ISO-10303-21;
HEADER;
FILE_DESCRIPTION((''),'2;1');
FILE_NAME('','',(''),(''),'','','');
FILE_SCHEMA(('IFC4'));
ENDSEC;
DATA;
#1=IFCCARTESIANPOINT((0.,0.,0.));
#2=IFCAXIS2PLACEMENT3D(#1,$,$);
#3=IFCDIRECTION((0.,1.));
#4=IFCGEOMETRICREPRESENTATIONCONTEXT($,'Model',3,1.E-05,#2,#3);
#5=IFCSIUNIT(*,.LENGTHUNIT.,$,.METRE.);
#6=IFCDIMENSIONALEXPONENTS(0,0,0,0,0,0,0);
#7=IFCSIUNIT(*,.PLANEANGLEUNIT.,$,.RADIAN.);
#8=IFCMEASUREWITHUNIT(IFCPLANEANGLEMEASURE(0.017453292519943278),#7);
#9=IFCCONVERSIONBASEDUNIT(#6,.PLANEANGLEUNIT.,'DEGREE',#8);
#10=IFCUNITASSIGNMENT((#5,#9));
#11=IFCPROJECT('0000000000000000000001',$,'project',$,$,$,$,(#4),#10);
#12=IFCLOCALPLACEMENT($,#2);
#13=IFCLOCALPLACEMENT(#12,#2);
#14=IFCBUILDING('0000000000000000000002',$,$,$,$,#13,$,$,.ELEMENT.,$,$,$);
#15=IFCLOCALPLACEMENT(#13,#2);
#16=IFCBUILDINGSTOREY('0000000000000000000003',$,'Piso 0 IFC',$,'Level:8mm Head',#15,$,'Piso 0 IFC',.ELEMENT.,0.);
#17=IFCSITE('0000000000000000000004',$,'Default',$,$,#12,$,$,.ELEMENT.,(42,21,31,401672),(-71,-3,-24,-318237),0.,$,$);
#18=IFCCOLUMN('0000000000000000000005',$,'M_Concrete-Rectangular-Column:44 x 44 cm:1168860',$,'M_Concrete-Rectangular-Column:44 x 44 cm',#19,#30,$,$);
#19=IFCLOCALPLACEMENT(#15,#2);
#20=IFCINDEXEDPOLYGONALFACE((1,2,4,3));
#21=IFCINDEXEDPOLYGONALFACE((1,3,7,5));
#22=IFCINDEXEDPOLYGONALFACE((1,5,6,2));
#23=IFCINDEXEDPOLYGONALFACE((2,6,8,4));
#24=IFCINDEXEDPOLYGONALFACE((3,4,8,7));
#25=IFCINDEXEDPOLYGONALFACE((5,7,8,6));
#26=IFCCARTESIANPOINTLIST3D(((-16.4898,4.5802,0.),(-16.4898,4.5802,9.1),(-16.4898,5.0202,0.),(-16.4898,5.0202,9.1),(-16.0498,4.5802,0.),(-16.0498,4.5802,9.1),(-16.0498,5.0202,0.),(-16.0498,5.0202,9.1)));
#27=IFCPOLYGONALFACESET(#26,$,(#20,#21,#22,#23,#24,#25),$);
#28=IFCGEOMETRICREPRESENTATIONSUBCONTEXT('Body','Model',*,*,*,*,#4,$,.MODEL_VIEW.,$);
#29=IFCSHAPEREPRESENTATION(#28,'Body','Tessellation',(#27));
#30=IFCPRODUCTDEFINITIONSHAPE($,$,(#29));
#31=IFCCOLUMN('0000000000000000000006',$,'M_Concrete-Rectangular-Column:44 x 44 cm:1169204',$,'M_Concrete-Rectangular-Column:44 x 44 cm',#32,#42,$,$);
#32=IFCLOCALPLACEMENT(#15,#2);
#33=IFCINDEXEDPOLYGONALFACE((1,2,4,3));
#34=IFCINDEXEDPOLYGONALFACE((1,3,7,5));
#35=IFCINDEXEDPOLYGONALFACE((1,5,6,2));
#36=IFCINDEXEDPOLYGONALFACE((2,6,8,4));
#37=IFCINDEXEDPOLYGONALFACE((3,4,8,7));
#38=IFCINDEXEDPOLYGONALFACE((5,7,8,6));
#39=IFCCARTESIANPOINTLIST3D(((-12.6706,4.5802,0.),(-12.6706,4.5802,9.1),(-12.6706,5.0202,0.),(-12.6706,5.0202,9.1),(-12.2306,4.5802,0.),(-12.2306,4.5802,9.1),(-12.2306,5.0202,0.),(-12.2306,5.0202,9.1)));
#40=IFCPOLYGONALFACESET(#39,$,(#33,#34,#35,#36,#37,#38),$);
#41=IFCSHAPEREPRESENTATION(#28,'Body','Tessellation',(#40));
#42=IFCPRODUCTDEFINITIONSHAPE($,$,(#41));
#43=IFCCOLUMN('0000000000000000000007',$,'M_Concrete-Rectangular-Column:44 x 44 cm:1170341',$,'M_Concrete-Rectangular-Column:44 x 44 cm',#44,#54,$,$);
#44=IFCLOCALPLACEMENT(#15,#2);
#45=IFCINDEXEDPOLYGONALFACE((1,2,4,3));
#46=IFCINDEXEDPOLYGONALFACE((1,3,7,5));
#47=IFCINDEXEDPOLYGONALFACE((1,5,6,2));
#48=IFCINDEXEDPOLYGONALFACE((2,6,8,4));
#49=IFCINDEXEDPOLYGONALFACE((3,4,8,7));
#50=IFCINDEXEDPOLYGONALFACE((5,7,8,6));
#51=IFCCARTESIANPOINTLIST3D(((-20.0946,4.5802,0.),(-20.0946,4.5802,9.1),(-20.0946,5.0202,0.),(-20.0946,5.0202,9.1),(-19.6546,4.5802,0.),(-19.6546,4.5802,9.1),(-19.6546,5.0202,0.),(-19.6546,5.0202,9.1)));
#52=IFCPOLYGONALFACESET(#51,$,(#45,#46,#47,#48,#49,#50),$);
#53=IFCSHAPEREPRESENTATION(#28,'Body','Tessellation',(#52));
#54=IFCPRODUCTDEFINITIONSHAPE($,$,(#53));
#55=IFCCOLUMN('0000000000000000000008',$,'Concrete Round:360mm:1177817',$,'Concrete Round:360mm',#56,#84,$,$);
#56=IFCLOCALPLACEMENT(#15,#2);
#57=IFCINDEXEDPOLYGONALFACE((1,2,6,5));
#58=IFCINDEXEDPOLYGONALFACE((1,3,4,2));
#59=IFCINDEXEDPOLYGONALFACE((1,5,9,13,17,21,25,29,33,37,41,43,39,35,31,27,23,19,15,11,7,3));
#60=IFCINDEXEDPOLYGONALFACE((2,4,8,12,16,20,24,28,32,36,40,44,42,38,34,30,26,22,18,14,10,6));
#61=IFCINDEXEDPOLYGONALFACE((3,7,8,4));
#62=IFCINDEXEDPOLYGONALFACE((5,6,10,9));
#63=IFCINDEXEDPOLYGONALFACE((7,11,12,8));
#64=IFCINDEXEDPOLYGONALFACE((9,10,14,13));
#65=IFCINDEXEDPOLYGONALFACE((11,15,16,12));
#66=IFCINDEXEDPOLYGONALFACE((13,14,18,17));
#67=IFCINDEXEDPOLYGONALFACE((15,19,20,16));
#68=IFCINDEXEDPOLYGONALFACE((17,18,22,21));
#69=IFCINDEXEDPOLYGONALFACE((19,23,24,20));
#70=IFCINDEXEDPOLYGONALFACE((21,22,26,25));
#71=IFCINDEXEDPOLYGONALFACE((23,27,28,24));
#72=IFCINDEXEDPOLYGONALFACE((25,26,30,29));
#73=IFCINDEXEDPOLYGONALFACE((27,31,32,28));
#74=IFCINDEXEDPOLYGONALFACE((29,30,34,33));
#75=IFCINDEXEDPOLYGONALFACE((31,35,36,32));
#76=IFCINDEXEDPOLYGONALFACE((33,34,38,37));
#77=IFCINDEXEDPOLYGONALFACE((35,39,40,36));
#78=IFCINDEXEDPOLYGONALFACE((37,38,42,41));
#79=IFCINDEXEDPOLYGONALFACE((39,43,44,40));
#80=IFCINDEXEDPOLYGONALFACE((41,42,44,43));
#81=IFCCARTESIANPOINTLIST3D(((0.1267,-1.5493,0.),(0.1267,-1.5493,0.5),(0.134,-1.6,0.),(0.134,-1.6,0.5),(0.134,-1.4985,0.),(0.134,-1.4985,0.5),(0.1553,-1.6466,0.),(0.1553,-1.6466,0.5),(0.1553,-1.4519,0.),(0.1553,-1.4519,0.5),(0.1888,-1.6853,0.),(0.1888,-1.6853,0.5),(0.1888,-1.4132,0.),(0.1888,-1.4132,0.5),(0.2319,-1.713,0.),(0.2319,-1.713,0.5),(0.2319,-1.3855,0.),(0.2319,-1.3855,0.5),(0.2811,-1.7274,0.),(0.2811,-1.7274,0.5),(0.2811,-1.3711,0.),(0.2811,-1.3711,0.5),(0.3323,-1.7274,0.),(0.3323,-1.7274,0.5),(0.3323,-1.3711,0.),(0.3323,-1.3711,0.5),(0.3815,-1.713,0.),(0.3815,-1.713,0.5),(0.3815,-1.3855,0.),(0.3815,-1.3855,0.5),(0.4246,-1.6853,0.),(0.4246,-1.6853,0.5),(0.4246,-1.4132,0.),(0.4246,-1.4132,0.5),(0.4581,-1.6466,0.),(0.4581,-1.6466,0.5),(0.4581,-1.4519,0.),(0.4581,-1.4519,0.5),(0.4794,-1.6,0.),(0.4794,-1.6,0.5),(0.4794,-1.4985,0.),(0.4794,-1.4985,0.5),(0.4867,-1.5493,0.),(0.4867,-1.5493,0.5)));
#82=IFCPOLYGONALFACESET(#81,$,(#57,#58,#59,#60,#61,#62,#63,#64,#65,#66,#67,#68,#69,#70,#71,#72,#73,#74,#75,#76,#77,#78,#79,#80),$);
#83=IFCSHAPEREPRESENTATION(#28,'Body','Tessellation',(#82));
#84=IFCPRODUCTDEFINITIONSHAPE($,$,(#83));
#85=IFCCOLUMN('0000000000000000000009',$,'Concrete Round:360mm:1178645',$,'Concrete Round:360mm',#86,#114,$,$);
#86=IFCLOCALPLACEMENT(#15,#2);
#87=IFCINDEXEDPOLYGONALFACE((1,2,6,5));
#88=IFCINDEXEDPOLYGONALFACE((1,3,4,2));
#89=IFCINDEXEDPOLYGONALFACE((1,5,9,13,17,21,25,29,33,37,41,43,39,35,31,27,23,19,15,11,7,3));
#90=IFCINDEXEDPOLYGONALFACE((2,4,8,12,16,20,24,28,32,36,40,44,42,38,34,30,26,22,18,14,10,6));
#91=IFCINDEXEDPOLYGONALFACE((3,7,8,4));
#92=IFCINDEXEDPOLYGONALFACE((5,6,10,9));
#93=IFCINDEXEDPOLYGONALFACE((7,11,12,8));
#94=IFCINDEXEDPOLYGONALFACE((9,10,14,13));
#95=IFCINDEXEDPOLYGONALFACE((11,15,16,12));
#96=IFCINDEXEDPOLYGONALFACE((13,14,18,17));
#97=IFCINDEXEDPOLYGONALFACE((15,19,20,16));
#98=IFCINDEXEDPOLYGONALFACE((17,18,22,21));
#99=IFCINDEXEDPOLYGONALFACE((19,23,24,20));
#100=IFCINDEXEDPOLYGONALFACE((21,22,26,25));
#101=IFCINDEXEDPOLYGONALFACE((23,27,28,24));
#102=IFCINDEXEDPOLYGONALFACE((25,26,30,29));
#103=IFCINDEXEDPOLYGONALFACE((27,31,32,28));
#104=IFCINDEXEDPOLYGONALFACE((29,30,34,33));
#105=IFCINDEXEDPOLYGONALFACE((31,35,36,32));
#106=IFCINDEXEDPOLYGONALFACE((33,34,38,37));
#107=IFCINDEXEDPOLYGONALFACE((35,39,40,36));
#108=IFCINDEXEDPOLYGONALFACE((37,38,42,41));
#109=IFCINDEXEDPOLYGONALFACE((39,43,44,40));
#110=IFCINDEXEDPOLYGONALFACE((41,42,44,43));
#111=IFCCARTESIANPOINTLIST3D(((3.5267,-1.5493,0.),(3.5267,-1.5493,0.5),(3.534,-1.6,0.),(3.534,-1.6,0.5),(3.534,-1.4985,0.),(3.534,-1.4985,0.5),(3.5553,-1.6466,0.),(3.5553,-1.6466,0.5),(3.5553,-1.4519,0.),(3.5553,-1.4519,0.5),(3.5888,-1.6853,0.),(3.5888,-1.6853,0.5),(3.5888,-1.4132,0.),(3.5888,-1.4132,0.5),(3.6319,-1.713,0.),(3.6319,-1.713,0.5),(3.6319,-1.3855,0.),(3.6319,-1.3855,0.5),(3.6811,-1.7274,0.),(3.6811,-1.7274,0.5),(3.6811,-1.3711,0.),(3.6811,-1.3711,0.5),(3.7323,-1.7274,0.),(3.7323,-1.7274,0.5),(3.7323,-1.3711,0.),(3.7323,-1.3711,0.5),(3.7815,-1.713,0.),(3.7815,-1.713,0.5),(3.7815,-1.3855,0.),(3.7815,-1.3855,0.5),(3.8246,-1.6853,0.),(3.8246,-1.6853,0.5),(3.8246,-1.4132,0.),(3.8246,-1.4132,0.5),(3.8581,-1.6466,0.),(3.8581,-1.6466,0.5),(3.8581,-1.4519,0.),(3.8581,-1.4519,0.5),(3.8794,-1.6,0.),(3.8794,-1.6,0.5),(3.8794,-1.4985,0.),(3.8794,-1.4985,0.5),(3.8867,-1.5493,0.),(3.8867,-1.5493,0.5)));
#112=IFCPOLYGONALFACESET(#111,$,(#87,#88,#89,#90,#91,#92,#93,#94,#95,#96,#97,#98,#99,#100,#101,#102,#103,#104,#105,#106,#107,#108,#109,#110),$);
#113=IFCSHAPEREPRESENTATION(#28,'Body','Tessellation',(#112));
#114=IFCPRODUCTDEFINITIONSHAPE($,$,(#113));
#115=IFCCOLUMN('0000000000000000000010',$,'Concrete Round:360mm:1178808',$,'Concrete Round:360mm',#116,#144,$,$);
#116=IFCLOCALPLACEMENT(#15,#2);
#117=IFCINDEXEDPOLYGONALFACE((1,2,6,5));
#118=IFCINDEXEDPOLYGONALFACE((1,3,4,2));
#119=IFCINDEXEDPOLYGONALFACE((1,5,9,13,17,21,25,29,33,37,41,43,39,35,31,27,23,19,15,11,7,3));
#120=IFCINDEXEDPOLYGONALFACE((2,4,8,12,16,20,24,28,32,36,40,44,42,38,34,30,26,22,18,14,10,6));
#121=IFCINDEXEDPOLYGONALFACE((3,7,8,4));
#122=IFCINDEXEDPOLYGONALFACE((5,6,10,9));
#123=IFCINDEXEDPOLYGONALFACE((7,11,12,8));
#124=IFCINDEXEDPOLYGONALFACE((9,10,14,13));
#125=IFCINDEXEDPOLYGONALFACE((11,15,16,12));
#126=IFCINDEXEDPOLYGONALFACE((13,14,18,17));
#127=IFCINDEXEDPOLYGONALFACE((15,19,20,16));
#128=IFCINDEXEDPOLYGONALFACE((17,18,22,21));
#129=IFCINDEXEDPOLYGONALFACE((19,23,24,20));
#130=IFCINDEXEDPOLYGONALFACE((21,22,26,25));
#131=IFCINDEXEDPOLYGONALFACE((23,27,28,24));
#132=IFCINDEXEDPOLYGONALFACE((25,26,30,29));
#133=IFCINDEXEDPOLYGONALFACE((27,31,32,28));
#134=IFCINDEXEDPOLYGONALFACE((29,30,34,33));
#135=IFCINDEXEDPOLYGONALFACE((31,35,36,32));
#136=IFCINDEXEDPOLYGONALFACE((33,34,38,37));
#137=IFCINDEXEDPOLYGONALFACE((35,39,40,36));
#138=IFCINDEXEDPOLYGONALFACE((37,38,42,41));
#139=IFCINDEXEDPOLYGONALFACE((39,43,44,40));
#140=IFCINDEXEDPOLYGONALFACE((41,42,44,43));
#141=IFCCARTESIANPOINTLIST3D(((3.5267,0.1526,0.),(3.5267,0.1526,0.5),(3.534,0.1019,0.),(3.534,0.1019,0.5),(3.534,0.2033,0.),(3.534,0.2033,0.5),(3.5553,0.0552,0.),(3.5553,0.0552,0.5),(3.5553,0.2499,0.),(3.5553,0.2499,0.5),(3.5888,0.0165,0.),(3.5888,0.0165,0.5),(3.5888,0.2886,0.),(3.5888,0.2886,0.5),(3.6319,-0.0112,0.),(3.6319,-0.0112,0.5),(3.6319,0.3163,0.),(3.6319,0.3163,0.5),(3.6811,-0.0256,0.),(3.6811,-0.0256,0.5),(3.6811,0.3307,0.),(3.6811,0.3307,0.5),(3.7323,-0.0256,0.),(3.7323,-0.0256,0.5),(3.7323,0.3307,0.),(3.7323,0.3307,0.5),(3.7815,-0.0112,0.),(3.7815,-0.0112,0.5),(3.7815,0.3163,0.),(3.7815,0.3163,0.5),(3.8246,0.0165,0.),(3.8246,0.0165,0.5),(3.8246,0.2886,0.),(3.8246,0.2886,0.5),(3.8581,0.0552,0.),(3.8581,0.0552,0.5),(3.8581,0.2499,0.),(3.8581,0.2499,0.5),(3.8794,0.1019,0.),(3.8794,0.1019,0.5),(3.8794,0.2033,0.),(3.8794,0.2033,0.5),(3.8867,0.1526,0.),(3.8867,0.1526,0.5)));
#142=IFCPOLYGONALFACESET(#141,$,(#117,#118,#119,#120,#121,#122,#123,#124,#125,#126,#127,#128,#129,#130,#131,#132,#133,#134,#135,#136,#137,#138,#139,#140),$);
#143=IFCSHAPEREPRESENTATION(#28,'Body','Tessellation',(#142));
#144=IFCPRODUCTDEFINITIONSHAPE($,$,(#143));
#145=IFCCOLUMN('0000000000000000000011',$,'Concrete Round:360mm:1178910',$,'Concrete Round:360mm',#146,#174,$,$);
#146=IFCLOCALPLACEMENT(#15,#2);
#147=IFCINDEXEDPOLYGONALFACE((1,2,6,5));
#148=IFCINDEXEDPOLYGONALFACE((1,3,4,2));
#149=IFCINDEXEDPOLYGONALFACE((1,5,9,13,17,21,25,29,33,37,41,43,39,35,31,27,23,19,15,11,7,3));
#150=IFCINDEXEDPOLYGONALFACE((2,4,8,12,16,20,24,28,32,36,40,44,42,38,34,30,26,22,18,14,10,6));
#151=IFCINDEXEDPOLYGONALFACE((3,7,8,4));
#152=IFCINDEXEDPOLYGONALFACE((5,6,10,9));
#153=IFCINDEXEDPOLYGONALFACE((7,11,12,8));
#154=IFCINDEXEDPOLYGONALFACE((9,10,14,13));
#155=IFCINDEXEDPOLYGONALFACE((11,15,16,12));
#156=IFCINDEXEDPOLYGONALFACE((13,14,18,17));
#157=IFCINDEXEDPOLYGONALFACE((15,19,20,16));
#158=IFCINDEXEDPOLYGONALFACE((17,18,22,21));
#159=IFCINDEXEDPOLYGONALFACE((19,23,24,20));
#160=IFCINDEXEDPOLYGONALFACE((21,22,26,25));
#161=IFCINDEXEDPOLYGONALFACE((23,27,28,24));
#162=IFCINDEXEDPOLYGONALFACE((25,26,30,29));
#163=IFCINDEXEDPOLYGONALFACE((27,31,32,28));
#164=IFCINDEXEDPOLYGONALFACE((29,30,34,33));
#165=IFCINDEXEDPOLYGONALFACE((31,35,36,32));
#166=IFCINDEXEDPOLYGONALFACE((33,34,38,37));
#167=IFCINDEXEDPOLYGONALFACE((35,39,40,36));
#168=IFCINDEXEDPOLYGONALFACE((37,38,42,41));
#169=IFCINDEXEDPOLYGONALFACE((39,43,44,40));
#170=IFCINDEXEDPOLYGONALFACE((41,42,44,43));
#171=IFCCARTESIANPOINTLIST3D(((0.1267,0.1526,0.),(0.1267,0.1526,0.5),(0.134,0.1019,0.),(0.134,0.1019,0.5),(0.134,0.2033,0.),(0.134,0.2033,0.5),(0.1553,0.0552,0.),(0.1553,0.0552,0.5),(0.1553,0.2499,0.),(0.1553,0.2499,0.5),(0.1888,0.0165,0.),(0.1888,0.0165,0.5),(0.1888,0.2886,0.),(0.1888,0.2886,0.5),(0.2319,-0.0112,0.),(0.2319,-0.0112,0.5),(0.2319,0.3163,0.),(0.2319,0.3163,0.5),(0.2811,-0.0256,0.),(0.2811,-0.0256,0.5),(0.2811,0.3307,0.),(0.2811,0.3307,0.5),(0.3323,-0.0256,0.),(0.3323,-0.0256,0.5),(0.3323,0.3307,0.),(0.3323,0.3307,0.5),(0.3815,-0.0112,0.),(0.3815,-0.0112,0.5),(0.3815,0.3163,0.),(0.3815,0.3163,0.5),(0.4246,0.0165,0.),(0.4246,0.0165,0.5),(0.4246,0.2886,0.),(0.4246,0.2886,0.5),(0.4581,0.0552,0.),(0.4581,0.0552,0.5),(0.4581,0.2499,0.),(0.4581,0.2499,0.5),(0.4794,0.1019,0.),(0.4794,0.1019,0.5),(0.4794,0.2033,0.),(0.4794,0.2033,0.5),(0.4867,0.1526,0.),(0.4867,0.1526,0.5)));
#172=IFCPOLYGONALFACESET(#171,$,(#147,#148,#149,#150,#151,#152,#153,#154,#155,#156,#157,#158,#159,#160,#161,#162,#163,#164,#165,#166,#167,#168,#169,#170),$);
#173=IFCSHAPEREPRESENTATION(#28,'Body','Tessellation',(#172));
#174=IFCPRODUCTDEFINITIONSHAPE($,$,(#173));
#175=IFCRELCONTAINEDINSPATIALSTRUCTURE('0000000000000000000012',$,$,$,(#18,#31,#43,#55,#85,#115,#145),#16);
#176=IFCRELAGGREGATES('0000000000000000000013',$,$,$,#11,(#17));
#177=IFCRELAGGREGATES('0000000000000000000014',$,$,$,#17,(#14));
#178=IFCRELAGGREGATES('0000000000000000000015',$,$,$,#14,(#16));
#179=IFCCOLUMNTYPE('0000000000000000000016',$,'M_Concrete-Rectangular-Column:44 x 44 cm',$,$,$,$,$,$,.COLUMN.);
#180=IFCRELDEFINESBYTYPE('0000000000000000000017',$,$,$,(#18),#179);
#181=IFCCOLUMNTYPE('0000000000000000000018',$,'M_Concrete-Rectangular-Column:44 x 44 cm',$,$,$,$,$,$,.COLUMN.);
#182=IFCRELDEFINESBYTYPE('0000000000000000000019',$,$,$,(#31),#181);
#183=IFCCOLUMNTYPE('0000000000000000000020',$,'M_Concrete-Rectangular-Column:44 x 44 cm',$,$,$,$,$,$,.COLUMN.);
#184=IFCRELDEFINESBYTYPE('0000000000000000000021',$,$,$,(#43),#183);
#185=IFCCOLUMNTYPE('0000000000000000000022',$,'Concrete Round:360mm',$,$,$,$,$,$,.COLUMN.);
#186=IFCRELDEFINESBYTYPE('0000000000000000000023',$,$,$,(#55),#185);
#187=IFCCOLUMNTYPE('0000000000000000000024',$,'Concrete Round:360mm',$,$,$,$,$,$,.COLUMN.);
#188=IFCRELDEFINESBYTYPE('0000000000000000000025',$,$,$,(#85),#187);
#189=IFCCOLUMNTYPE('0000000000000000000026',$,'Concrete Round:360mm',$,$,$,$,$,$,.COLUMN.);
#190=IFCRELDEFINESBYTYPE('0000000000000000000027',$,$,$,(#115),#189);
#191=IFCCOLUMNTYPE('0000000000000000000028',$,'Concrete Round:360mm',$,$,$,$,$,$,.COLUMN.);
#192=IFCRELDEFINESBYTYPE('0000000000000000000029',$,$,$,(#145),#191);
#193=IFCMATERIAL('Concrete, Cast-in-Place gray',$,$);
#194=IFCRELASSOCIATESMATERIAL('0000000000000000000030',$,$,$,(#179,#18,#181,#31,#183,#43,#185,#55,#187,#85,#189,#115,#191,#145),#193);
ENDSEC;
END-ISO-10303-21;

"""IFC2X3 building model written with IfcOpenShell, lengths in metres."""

from ifc_helpers import new_model, entity, si_unit, converted_unit, direction, frame, frame_2d, origin, place, context, subcontext, project, spatial, rectangle, circle, extrude, source, transform, mapped, material, type_object, type_shapes, element, save


model = new_model("IFC2X3")

# Units and contexts
model_context = context("Model", 3, precision=1e-05, world=origin(), true_north=direction((0.0, 1.0)))
body_context = subcontext(model_context, "Body", "Model", "MODEL_VIEW")
ifc_project = project(units=[si_unit("LENGTHUNIT", "METRE"), converted_unit("PLANEANGLEUNIT", "DEGREE", entity("IfcPlaneAngleMeasure", 0.017453292519943278), si_unit("PLANEANGLEUNIT", "RADIAN"), dimensions=[0, 0, 0, 0, 0, 0, 0])], contexts=[model_context])

# Site, building, storey
site_placement = place(None, origin())
site = spatial("IfcSite", under=ifc_project, at=site_placement, Name="Default", CompositionType="ELEMENT", RefLatitude=(42, 21, 31, 401672), RefLongitude=(-71, -3, -24, -318237), RefElevation=0.0)
building_placement = place(site_placement, origin())
building = spatial("IfcBuilding", under=site, at=building_placement, CompositionType="ELEMENT")
storey_placement = place(building_placement, origin())
storey = spatial("IfcBuildingStorey", under=building, at=storey_placement, Name="Piso 0 IFC", ObjectType="Level:8mm Head", LongName="Piso 0 IFC", CompositionType="ELEMENT", Elevation=0.0)

# Columns
ifc_material_1 = material(Name="Concrete, Cast-in-Place gray")
column_type_1 = type_object("IfcColumnType", Name="M_Concrete-Rectangular-Column:44 x 44 cm", PredefinedType="COLUMN", material=ifc_material_1)
shared_shape_1 = source(origin(), body_context, "Body", "SweptSolid", [
    extrude(rectangle(XDim=0.44, YDim=0.44, at=frame_2d((0.0, 0.0), x_axis=(1.0, 0.0))), frame((-16.2698, 4.8002, 0.0), z_axis=(0.0, 0.0, 1.0), x_axis=(-1.0, 0.0, 0.0)), (0.0, 0.0, 1.0), 9.1),
])
type_shapes(column_type_1, [shared_shape_1])
column_1_placement = place(storey_placement, origin())
element("IfcColumn", 1, at=column_1_placement, inside=storey, type_object=column_type_1, material=ifc_material_1, Name="M_Concrete-Rectangular-Column:44 x 44 cm:1168860", ObjectType="M_Concrete-Rectangular-Column:44 x 44 cm", context=body_context, shape_type="MappedRepresentation", body=[
    mapped(shared_shape_1, transform((0.0, 0.0, 0.0), scale=1.0)),
])
column_type_2 = type_object("IfcColumnType", Name="M_Concrete-Rectangular-Column:44 x 44 cm", PredefinedType="COLUMN", material=ifc_material_1)
shared_shape_2 = source(origin(), body_context, "Body", "SweptSolid", [
    extrude(rectangle(XDim=0.44, YDim=0.44, at=frame_2d((0.0, 0.0), x_axis=(1.0, 0.0))), frame((-12.4506, 4.8002, 0.0), z_axis=(0.0, 0.0, 1.0), x_axis=(-1.0, 0.0, 0.0)), (0.0, 0.0, 1.0), 9.1),
])
type_shapes(column_type_2, [shared_shape_2])
column_2_placement = place(storey_placement, origin())
element("IfcColumn", 2, at=column_2_placement, inside=storey, type_object=column_type_2, material=ifc_material_1, Name="M_Concrete-Rectangular-Column:44 x 44 cm:1169204", ObjectType="M_Concrete-Rectangular-Column:44 x 44 cm", context=body_context, shape_type="MappedRepresentation", body=[
    mapped(shared_shape_2, transform((0.0, 0.0, 0.0), scale=1.0)),
])
column_type_3 = type_object("IfcColumnType", Name="M_Concrete-Rectangular-Column:44 x 44 cm", PredefinedType="COLUMN", material=ifc_material_1)
shared_shape_3 = source(origin(), body_context, "Body", "SweptSolid", [
    extrude(rectangle(XDim=0.44, YDim=0.44, at=frame_2d((0.0, 0.0), x_axis=(1.0, 0.0))), frame((-19.8746, 4.8002, 0.0), z_axis=(0.0, 0.0, 1.0), x_axis=(-1.0, 0.0, 0.0)), (0.0, 0.0, 1.0), 9.1),
])
type_shapes(column_type_3, [shared_shape_3])
column_3_placement = place(storey_placement, origin())
element("IfcColumn", 3, at=column_3_placement, inside=storey, type_object=column_type_3, material=ifc_material_1, Name="M_Concrete-Rectangular-Column:44 x 44 cm:1170341", ObjectType="M_Concrete-Rectangular-Column:44 x 44 cm", context=body_context, shape_type="MappedRepresentation", body=[
    mapped(shared_shape_3, transform((0.0, 0.0, 0.0), scale=1.0)),
])
column_type_4 = type_object("IfcColumnType", Name="Concrete Round:360mm", PredefinedType="COLUMN", material=ifc_material_1)
shared_shape_4 = source(origin(), body_context, "Body", "SweptSolid", [
    extrude(circle(Radius=0.18, at=frame_2d((0.0, 0.0), x_axis=(1.0, 0.0))), frame((0.3067, -1.5493, 0.0)), (0.0, 0.0, 1.0), 0.5),
])
type_shapes(column_type_4, [shared_shape_4])
column_4_placement = place(storey_placement, origin())
element("IfcColumn", 4, at=column_4_placement, inside=storey, type_object=column_type_4, material=ifc_material_1, Name="Concrete Round:360mm:1177817", ObjectType="Concrete Round:360mm", context=body_context, shape_type="MappedRepresentation", body=[
    mapped(shared_shape_4, transform((0.0, 0.0, 0.0), scale=1.0)),
])
column_type_5 = type_object("IfcColumnType", Name="Concrete Round:360mm", PredefinedType="COLUMN", material=ifc_material_1)
shared_shape_5 = source(origin(), body_context, "Body", "SweptSolid", [
    extrude(circle(Radius=0.18, at=frame_2d((0.0, 0.0), x_axis=(1.0, 0.0))), frame((3.7067, -1.5493, 0.0)), (0.0, 0.0, 1.0), 0.5),
])
type_shapes(column_type_5, [shared_shape_5])
column_5_placement = place(storey_placement, origin())
element("IfcColumn", 5, at=column_5_placement, inside=storey, type_object=column_type_5, material=ifc_material_1, Name="Concrete Round:360mm:1178645", ObjectType="Concrete Round:360mm", context=body_context, shape_type="MappedRepresentation", body=[
    mapped(shared_shape_5, transform((0.0, 0.0, 0.0), scale=1.0)),
])
column_type_6 = type_object("IfcColumnType", Name="Concrete Round:360mm", PredefinedType="COLUMN", material=ifc_material_1)
shared_shape_6 = source(origin(), body_context, "Body", "SweptSolid", [
    extrude(circle(Radius=0.18, at=frame_2d((0.0, 0.0), x_axis=(1.0, 0.0))), frame((3.7067, 0.1526, 0.0)), (0.0, 0.0, 1.0), 0.5),
])
type_shapes(column_type_6, [shared_shape_6])
column_6_placement = place(storey_placement, origin())
element("IfcColumn", 6, at=column_6_placement, inside=storey, type_object=column_type_6, material=ifc_material_1, Name="Concrete Round:360mm:1178808", ObjectType="Concrete Round:360mm", context=body_context, shape_type="MappedRepresentation", body=[
    mapped(shared_shape_6, transform((0.0, 0.0, 0.0), scale=1.0)),
])
column_type_7 = type_object("IfcColumnType", Name="Concrete Round:360mm", PredefinedType="COLUMN", material=ifc_material_1)
shared_shape_7 = source(origin(), body_context, "Body", "SweptSolid", [
    extrude(circle(Radius=0.18, at=frame_2d((0.0, 0.0), x_axis=(1.0, 0.0))), frame((0.3067, 0.1526, 0.0)), (0.0, 0.0, 1.0), 0.5),
])
type_shapes(column_type_7, [shared_shape_7])
column_7_placement = place(storey_placement, origin())
element("IfcColumn", 7, at=column_7_placement, inside=storey, type_object=column_type_7, material=ifc_material_1, Name="Concrete Round:360mm:1178910", ObjectType="Concrete Round:360mm", context=body_context, shape_type="MappedRepresentation", body=[
    mapped(shared_shape_7, transform((0.0, 0.0, 0.0), scale=1.0)),
])

save(model, "model.ifc")
